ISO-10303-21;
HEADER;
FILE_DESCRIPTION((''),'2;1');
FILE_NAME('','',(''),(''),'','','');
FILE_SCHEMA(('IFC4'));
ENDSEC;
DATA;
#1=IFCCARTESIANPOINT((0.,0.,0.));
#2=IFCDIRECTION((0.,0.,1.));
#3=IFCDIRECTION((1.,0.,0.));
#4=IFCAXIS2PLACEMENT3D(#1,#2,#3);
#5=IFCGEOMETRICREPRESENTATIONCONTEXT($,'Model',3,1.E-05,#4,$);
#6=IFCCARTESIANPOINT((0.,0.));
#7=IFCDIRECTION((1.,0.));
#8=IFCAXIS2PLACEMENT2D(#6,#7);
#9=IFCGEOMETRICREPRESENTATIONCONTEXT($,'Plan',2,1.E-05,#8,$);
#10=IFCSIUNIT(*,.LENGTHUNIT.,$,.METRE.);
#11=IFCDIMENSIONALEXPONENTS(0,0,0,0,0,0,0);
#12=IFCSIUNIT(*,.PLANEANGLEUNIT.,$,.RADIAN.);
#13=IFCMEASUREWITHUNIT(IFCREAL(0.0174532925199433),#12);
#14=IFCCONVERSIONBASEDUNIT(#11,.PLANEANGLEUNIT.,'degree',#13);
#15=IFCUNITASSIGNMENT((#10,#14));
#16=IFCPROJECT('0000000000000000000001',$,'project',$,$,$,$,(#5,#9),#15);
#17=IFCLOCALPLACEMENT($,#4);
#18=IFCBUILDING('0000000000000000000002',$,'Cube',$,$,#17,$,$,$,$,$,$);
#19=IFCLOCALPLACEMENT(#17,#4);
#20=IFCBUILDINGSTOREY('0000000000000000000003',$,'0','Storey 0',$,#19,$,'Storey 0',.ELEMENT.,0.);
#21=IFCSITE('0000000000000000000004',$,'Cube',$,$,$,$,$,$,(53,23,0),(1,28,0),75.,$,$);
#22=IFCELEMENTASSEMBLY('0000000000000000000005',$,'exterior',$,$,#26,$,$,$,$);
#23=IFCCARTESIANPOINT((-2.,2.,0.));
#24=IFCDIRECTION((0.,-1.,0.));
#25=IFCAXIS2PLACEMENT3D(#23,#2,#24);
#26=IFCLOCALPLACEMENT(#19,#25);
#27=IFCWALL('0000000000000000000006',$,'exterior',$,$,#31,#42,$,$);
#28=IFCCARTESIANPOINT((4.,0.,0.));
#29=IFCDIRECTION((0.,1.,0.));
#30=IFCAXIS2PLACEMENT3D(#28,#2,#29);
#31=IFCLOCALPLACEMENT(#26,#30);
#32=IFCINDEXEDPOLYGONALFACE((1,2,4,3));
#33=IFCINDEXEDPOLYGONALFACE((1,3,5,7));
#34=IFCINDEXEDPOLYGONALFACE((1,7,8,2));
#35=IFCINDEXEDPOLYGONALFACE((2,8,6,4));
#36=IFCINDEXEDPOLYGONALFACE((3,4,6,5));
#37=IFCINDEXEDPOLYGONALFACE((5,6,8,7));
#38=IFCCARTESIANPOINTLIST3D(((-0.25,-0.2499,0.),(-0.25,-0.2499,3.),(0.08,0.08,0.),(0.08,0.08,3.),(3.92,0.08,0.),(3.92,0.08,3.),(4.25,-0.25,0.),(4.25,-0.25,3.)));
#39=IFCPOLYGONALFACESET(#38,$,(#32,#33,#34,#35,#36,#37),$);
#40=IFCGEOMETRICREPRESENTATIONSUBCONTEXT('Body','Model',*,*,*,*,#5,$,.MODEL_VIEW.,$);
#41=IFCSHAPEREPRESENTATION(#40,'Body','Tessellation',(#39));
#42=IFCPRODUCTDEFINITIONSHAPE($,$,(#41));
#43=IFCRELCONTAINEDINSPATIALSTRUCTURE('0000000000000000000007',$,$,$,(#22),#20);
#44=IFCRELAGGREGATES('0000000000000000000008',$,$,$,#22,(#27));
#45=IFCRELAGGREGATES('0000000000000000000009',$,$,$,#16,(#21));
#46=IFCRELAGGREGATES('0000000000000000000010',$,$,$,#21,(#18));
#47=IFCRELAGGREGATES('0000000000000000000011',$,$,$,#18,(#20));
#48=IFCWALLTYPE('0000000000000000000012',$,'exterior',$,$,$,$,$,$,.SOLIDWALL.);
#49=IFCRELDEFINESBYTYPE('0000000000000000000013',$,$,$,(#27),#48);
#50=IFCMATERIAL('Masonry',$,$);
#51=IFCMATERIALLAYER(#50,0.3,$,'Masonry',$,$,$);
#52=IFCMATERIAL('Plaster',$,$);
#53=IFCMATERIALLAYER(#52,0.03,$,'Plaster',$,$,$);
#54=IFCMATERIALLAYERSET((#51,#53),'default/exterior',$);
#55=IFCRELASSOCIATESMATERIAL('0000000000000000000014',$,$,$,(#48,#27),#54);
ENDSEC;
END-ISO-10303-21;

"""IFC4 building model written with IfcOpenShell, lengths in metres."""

from ifc_helpers import new_model, entity, si_unit, converted_unit, frame, origin, origin_with_axes, origin_2d_with_axis, place, context, subcontext, project, spatial, polyline, outline, extrude, material, layer, layer_set, layer_usage, type_object, element, aggregate, save


model = new_model("IFC4")

# Units and contexts
model_context = context("Model", 3, precision=1e-05, world=origin_with_axes())
plan_context = context("Plan", 2, precision=1e-05, world=origin_2d_with_axis())
body_context = subcontext(model_context, "Body", "Model", "MODEL_VIEW")
ifc_project = project(units=[si_unit("LENGTHUNIT", "METRE"), converted_unit("PLANEANGLEUNIT", "degree", entity("IfcReal", 0.0174532925199433), si_unit("PLANEANGLEUNIT", "RADIAN"), dimensions=[0, 0, 0, 0, 0, 0, 0])], contexts=[model_context, plan_context])

# Site, building, storey
site = spatial("IfcSite", under=ifc_project, Name="Cube", RefLatitude=(53, 23, 0), RefLongitude=(1, 28, 0), RefElevation=75.0)
building_placement = place(None, origin_with_axes())
building = spatial("IfcBuilding", under=site, at=building_placement, Name="Cube")
storey_placement = place(building_placement, origin_with_axes())
storey = spatial("IfcBuildingStorey", under=building, at=storey_placement, Name="0", Description="Storey 0", LongName="Storey 0", CompositionType="ELEMENT", Elevation=0.0)

# Element assembly, wall
assembly_1_placement = place(storey_placement, frame((-2.0, 2.0, 0.0), z_axis=(0.0, 0.0, 1.0), x_axis=(0.0, -1.0, 0.0)))
assembly_1 = element("IfcElementAssembly", 1, at=assembly_1_placement, inside=storey, Name="exterior")
ifc_material_1 = material(Name="Masonry")
ifc_layer_1 = layer(ifc_material_1, 0.3, Name="Masonry")
ifc_material_2 = material(Name="Plaster")
ifc_layer_2 = layer(ifc_material_2, 0.03, Name="Plaster")
ifc_layer_set_1 = layer_set([ifc_layer_1, ifc_layer_2], Name="default/exterior")
ifc_layer_usage_1 = layer_usage(ifc_layer_set_1, "AXIS2", "POSITIVE", -0.25)
wall_type = type_object("IfcWallType", Name="exterior", PredefinedType="SOLIDWALL", material=ifc_layer_set_1)
wall_placement = place(assembly_1_placement, frame((4.0, 0.0, 0.0), z_axis=(0.0, 0.0, 1.0), x_axis=(0.0, 1.0, 0.0)))
wall = element("IfcWall", 2, at=wall_placement, type_object=wall_type, material=ifc_layer_usage_1, Name="exterior", context=body_context, shape_type="SweptSolid", body=[
    extrude(outline(polyline([(0.08, 0.08), (-0.25, -0.2499), (4.25, -0.25), (3.92, 0.08), (0.08, 0.08)])), origin(), (0.0, 0.0, 1.0), 3.0),
])
aggregate(assembly_1, [wall])

save(model, "model.ifc")
